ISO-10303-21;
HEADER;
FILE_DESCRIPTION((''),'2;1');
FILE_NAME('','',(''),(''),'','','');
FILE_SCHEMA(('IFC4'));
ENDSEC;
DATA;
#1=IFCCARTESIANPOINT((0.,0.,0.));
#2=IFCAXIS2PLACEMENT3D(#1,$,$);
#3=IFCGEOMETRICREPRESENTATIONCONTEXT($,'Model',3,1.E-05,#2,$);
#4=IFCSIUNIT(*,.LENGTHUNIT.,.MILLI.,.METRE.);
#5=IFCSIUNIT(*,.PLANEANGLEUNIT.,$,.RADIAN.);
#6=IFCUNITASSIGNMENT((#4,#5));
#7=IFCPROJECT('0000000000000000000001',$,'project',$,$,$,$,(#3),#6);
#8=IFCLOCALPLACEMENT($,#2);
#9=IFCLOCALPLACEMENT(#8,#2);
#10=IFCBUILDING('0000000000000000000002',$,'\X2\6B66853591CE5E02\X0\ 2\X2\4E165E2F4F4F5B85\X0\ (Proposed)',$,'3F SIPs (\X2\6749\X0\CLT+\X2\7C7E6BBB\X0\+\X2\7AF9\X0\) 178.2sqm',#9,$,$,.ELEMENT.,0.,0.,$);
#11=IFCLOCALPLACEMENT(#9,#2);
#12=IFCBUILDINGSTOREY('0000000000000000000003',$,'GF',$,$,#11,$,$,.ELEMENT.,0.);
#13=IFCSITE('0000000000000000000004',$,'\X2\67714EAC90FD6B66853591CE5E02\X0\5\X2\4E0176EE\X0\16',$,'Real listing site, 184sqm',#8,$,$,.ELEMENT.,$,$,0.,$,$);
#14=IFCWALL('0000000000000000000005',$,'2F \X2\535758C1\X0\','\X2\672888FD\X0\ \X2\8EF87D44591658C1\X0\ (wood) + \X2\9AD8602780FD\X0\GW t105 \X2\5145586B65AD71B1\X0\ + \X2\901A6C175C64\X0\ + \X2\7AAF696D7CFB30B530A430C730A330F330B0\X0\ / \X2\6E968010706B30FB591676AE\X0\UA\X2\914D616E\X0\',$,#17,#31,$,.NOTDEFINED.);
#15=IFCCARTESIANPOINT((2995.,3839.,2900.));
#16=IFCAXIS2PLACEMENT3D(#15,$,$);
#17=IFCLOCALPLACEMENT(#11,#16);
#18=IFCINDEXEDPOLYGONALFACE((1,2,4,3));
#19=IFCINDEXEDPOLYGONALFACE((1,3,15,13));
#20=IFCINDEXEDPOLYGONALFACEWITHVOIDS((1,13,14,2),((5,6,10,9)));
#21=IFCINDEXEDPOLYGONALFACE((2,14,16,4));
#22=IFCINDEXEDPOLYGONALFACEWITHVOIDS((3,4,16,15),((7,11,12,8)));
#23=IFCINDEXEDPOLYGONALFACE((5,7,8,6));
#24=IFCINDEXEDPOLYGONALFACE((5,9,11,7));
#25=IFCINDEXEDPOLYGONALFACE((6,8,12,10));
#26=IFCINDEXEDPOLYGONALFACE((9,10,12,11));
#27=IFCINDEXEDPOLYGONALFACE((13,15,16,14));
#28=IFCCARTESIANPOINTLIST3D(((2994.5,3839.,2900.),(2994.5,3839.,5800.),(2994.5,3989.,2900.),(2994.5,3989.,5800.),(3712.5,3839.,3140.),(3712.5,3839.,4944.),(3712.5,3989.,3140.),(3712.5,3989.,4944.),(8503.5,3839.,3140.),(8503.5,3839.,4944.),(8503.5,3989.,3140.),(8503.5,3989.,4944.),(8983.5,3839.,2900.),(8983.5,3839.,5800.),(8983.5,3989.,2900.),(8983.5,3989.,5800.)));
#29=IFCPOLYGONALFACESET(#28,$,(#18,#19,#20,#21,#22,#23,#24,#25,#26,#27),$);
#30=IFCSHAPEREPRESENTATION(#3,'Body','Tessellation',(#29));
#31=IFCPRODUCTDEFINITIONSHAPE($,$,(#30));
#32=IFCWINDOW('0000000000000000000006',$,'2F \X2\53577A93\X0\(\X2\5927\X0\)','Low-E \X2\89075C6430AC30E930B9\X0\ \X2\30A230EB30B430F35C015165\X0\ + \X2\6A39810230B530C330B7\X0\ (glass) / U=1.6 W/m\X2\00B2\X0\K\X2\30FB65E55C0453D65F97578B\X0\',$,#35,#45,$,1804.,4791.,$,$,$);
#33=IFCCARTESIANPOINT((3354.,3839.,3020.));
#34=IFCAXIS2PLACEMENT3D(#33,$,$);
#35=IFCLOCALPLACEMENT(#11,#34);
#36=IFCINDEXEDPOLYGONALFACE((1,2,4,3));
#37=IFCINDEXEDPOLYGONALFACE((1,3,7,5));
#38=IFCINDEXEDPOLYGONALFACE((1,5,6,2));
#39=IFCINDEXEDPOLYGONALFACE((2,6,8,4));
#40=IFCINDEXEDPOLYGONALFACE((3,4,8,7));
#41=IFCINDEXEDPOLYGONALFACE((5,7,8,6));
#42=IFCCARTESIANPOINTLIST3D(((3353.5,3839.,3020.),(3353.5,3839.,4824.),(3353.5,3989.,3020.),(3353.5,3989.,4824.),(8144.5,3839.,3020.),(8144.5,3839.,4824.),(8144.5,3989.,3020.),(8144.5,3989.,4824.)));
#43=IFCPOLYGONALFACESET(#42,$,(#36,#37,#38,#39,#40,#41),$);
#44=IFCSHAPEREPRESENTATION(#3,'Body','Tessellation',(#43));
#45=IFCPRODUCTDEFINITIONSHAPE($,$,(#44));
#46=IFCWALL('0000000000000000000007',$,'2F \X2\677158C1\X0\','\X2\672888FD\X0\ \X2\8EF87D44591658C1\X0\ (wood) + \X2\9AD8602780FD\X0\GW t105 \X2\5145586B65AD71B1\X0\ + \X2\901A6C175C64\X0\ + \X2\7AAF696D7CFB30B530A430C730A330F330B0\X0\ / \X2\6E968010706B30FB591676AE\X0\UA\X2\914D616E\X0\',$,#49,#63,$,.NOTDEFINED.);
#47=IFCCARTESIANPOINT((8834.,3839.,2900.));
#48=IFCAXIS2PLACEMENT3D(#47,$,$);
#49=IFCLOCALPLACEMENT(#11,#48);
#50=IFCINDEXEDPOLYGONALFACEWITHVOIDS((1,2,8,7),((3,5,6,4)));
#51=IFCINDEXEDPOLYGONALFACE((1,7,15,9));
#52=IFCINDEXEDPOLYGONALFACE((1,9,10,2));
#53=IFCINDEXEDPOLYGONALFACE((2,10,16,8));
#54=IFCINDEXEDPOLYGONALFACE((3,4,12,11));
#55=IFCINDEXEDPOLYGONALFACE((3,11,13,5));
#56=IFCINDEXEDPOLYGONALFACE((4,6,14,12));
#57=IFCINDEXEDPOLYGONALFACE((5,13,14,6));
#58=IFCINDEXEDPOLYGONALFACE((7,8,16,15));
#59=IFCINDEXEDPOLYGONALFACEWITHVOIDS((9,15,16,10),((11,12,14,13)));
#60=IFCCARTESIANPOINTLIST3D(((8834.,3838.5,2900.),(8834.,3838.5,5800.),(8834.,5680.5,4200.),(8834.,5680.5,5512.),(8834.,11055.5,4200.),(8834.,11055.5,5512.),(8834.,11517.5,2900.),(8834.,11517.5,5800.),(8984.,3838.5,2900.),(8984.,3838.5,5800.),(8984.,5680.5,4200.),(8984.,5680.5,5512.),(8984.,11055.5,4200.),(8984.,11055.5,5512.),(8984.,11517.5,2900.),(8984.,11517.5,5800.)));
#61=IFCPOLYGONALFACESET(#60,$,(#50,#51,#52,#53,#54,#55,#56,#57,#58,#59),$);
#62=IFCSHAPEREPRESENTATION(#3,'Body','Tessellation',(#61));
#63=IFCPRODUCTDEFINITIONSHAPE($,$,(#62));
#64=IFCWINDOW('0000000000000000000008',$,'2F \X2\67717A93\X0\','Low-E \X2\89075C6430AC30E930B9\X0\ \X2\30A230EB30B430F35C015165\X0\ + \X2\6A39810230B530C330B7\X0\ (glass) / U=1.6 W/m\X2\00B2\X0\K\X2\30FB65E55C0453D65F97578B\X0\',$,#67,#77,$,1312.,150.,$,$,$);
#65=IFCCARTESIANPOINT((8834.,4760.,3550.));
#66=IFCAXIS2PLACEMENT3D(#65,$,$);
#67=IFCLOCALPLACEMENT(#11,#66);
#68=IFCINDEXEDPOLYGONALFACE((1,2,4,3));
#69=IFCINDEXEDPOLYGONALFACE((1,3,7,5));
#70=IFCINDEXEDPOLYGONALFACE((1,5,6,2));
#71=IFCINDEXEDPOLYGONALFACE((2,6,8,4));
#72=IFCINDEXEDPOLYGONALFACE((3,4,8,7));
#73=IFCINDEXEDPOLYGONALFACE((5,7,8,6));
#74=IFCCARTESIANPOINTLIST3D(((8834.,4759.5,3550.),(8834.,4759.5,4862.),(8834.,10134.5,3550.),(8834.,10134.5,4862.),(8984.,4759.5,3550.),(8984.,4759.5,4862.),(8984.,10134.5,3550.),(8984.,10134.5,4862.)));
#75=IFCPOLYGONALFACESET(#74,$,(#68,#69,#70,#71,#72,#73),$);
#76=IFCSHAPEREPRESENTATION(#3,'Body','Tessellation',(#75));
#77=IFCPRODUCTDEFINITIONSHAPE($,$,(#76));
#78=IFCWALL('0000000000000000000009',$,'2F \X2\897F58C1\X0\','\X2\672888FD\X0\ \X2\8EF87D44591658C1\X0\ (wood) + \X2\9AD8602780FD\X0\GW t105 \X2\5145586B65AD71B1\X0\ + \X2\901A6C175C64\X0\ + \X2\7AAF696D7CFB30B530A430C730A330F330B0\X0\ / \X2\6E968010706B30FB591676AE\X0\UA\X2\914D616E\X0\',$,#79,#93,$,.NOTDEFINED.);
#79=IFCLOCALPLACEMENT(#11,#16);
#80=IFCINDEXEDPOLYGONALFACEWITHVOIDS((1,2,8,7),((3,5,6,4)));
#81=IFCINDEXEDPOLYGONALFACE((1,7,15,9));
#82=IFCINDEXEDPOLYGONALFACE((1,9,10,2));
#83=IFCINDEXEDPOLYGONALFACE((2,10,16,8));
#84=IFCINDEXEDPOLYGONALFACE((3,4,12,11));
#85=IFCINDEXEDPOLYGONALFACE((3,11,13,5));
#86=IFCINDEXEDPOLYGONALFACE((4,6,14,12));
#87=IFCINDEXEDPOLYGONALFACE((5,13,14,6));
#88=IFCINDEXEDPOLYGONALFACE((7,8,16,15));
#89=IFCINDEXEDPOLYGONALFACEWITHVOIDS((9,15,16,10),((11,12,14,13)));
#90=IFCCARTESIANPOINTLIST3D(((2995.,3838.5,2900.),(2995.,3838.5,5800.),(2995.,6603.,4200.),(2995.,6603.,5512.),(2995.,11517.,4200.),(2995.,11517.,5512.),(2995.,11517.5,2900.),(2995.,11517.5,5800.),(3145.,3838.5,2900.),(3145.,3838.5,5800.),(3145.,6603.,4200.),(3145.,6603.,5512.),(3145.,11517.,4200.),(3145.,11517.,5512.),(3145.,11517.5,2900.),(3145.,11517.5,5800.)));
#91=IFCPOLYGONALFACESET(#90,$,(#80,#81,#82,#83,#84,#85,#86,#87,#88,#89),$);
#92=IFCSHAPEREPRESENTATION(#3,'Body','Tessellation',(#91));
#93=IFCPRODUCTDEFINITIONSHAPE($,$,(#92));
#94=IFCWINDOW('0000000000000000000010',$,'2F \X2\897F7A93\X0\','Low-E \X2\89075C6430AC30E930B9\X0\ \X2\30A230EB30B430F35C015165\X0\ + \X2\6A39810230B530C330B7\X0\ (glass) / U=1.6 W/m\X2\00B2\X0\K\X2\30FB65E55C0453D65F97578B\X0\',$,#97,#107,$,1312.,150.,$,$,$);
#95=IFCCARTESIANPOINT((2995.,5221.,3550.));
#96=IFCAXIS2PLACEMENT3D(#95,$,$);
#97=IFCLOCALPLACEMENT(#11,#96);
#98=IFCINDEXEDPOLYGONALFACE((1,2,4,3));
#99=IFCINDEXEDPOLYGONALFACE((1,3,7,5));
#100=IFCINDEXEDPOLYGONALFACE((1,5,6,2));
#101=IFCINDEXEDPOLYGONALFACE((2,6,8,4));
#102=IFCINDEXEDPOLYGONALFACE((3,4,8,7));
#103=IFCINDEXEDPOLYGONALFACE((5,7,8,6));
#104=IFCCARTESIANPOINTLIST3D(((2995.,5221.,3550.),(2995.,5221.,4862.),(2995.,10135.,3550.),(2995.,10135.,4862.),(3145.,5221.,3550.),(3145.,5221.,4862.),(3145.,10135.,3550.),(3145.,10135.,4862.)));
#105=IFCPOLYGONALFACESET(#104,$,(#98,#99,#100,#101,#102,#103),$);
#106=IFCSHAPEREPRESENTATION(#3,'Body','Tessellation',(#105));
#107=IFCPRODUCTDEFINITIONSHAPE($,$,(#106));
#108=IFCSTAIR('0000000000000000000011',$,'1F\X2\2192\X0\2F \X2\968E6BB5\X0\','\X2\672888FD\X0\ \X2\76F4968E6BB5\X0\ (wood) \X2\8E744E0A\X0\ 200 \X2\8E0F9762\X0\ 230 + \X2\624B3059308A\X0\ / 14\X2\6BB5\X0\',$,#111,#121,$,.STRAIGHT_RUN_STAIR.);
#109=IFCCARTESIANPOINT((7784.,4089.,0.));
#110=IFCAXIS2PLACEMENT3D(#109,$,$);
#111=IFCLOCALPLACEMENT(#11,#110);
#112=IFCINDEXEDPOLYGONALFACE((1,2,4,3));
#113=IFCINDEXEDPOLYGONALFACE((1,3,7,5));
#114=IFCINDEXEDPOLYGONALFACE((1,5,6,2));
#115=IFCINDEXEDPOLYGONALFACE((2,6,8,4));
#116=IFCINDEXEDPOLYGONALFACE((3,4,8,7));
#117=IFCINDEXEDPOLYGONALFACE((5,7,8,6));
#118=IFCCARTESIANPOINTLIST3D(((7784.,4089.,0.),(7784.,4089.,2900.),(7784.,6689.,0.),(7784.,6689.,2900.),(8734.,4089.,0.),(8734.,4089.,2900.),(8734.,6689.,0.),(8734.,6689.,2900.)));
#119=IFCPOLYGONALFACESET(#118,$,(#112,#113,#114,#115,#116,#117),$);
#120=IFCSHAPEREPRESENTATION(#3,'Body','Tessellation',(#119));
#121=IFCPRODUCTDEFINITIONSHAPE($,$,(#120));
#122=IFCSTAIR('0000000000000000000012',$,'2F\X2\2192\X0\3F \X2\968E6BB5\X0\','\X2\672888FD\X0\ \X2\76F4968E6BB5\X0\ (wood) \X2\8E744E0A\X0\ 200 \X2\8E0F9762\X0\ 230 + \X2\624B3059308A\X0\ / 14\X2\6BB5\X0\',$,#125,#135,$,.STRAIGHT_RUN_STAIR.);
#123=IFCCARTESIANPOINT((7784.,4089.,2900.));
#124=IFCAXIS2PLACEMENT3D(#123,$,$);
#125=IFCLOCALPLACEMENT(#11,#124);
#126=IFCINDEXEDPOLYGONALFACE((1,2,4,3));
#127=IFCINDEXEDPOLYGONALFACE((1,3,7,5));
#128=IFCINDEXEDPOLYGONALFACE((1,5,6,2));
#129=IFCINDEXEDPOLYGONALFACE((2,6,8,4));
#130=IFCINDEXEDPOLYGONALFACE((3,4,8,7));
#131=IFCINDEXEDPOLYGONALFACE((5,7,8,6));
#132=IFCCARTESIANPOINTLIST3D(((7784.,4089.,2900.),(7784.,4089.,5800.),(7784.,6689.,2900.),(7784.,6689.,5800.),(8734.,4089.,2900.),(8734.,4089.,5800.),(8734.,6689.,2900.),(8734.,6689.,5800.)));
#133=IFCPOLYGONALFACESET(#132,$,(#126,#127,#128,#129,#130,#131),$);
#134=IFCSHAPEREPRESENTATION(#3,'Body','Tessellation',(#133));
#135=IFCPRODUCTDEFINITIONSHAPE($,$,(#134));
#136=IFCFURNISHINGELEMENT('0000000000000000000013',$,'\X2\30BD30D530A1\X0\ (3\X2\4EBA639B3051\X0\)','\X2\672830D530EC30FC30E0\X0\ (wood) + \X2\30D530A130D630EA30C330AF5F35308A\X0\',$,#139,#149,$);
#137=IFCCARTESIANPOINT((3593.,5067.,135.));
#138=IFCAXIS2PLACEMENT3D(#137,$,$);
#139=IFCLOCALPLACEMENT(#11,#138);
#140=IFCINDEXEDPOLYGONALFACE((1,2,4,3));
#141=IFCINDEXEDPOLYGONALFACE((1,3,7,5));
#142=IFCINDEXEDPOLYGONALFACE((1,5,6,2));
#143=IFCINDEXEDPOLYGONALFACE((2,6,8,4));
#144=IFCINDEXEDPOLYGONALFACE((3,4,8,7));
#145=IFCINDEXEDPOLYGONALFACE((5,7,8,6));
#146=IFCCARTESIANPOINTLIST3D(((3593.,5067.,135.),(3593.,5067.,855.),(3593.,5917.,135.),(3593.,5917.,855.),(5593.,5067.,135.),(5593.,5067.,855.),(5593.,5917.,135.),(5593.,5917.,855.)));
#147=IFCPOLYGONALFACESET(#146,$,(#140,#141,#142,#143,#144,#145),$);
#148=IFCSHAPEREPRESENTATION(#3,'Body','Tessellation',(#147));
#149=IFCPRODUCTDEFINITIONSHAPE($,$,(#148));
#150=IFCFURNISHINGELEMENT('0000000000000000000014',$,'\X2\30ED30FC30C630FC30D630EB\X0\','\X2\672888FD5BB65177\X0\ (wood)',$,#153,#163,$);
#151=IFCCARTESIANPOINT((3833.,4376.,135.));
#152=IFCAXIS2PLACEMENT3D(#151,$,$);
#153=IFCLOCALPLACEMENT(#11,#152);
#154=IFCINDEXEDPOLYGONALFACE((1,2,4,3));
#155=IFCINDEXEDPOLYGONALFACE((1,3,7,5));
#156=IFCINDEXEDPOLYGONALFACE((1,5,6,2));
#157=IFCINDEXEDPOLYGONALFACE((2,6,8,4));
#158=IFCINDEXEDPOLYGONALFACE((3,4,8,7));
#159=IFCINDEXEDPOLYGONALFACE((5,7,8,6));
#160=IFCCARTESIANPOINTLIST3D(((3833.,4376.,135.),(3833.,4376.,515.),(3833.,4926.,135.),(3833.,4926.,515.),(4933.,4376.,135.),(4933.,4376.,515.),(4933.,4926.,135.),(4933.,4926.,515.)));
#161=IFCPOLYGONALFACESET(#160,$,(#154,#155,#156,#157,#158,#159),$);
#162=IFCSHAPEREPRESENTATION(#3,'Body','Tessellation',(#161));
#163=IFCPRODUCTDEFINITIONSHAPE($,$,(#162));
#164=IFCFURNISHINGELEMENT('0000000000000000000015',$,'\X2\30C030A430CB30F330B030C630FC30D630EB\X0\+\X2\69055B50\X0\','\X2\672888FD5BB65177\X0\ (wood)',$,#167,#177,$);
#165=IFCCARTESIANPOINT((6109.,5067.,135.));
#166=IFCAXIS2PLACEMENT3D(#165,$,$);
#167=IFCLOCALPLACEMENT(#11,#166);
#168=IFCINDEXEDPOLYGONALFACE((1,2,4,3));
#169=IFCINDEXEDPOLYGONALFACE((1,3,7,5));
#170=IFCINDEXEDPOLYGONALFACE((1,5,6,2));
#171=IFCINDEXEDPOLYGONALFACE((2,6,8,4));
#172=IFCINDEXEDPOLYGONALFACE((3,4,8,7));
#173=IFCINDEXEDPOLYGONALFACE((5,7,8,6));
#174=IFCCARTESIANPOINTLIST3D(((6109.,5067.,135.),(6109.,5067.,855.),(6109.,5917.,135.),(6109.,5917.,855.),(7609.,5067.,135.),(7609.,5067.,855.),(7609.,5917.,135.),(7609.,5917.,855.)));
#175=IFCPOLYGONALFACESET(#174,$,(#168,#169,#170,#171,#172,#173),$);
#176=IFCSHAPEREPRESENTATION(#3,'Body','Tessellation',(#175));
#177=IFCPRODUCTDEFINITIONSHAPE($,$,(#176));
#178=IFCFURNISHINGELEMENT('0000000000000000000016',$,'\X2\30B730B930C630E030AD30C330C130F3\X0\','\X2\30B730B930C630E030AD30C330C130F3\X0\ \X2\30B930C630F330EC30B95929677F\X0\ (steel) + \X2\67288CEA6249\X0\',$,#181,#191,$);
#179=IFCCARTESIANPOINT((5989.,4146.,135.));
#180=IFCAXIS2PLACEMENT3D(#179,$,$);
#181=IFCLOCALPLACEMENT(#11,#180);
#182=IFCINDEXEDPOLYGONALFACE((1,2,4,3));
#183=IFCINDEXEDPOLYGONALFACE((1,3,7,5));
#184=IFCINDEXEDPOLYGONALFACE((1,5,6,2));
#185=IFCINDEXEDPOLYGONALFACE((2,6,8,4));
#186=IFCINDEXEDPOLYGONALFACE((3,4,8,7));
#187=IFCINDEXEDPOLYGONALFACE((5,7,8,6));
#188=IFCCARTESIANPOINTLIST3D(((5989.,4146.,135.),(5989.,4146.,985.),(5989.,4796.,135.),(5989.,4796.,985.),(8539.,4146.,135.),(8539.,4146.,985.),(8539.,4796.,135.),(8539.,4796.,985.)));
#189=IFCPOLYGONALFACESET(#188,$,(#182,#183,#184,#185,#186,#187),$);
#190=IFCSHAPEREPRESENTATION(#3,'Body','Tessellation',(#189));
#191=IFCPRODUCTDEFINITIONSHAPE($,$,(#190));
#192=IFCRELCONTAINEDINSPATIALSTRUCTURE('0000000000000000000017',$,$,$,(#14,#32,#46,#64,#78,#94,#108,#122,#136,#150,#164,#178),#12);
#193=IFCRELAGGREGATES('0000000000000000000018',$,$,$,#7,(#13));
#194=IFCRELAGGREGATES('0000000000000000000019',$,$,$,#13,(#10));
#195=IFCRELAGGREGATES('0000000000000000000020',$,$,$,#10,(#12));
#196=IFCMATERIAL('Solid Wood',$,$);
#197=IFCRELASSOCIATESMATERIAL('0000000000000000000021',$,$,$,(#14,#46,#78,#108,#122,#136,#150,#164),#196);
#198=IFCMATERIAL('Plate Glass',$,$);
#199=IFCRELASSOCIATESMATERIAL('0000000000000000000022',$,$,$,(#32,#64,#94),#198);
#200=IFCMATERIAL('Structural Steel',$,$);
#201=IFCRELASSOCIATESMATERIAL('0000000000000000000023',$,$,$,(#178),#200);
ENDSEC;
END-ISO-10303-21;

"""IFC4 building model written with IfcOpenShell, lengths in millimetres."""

from ifc_helpers import new_model, si_unit, frame, frame_2d, origin, place, context, project, spatial, rectangle, extrude, material, element, fill, save


model = new_model("IFC4")

# Units and contexts
model_context = context("Model", 3, precision=1e-05, world=origin())
ifc_project = project(units=[si_unit("LENGTHUNIT", "METRE", prefix="MILLI"), si_unit("PLANEANGLEUNIT", "RADIAN")], contexts=[model_context])

# Site, building, storey
site_placement = place(None, origin())
site = spatial("IfcSite", under=ifc_project, at=site_placement, Name="東京都武蔵野市5丁目16", ObjectType="Real listing site, 184sqm", CompositionType="ELEMENT", RefElevation=0.0)
building_placement = place(site_placement, origin())
building = spatial("IfcBuilding", under=site, at=building_placement, Name="武蔵野市 2世帯住宅 (Proposed)", ObjectType="3F SIPs (杉CLT+籾殻+竹) 178.2sqm", CompositionType="ELEMENT", ElevationOfRefHeight=0.0, ElevationOfTerrain=0.0)
storey_placement = place(building_placement, origin())
storey = spatial("IfcBuildingStorey", under=building, at=storey_placement, Name="GF", CompositionType="ELEMENT", Elevation=0.0)

# Shared definitions
ifc_material_1 = material(Name="Solid Wood")

# Shared definitions
ifc_material_2 = material(Name="Plate Glass")

# Walls, openings, windows
wall_1_placement = place(storey_placement, frame((2995.0, 3839.0, 2900.0)))
wall_1 = element("IfcWall", 1, at=wall_1_placement, inside=storey, material=ifc_material_1, Name="2F 南壁", Description="木製 軸組外壁 (wood) + 高性能GW t105 充填断熱 + 通気層 + 窯業系サイディング / 準耐火・外皮UA配慮", PredefinedType="NOTDEFINED", context=model_context, shape_type="SweptSolid", body=[
    extrude(rectangle(XDim=5989.0, YDim=150.0, at=frame_2d((2994.0, 75.0))), frame((2995.0, 3839.0, 2900.0)), (0.0, 0.0, 1.0), 2900.0),
])
opening_1_placement = place(storey_placement, frame((3354.0, 3839.0, 3020.0)))
opening_1 = element("IfcOpeningElement", 2, at=opening_1_placement, cuts=wall_1, PredefinedType="NOTDEFINED", context=model_context, shape_type="SweptSolid", body=[
    extrude(rectangle(XDim=4791.0, YDim=150.0, at=frame_2d((2395.0, 75.0))), frame((3354.0, 3839.0, 3020.0)), (0.0, 0.0, 1.0), 1804.0),
])
window_1_placement = place(storey_placement, frame((3354.0, 3839.0, 3020.0)))
window_1 = element("IfcWindow", 3, at=window_1_placement, inside=storey, material=ifc_material_2, Name="2F 南窓(大)", Description="Low-E 複層ガラス アルゴン封入 + 樹脂サッシ (glass) / U=1.6 W/m²K・日射取得型", OverallHeight=1804.0, OverallWidth=4791.0, context=model_context, shape_type="SweptSolid", body=[
    extrude(rectangle(XDim=4791.0, YDim=150.0, at=frame_2d((2395.0, 75.0))), frame((3354.0, 3839.0, 3020.0)), (0.0, 0.0, 1.0), 1804.0),
])
fill(opening_1, window_1)
wall_2_placement = place(storey_placement, frame((8834.0, 3839.0, 2900.0)))
wall_2 = element("IfcWall", 4, at=wall_2_placement, inside=storey, material=ifc_material_1, Name="2F 東壁", Description="木製 軸組外壁 (wood) + 高性能GW t105 充填断熱 + 通気層 + 窯業系サイディング / 準耐火・外皮UA配慮", PredefinedType="NOTDEFINED", context=model_context, shape_type="SweptSolid", body=[
    extrude(rectangle(XDim=150.0, YDim=7679.0, at=frame_2d((75.0, 3839.0))), frame((8834.0, 3839.0, 2900.0)), (0.0, 0.0, 1.0), 2900.0),
])
opening_2_placement = place(storey_placement, frame((8834.0, 4760.0, 3550.0)))
opening_2 = element("IfcOpeningElement", 5, at=opening_2_placement, cuts=wall_2, PredefinedType="NOTDEFINED", context=model_context, shape_type="SweptSolid", body=[
    extrude(rectangle(XDim=150.0, YDim=5375.0, at=frame_2d((75.0, 2687.0))), frame((8834.0, 4760.0, 3550.0)), (0.0, 0.0, 1.0), 1312.0),
])
window_2_placement = place(storey_placement, frame((8834.0, 4760.0, 3550.0)))
window_2 = element("IfcWindow", 6, at=window_2_placement, inside=storey, material=ifc_material_2, Name="2F 東窓", Description="Low-E 複層ガラス アルゴン封入 + 樹脂サッシ (glass) / U=1.6 W/m²K・日射取得型", OverallHeight=1312.0, OverallWidth=150.0, context=model_context, shape_type="SweptSolid", body=[
    extrude(rectangle(XDim=150.0, YDim=5375.0, at=frame_2d((75.0, 2687.0))), frame((8834.0, 4760.0, 3550.0)), (0.0, 0.0, 1.0), 1312.0),
])
fill(opening_2, window_2)
wall_3_placement = place(storey_placement, frame((2995.0, 3839.0, 2900.0)))
wall_3 = element("IfcWall", 7, at=wall_3_placement, inside=storey, material=ifc_material_1, Name="2F 西壁", Description="木製 軸組外壁 (wood) + 高性能GW t105 充填断熱 + 通気層 + 窯業系サイディング / 準耐火・外皮UA配慮", PredefinedType="NOTDEFINED", context=model_context, shape_type="SweptSolid", body=[
    extrude(rectangle(XDim=150.0, YDim=7679.0, at=frame_2d((75.0, 3839.0))), frame((2995.0, 3839.0, 2900.0)), (0.0, 0.0, 1.0), 2900.0),
])
opening_3_placement = place(storey_placement, frame((2995.0, 5221.0, 3550.0)))
opening_3 = element("IfcOpeningElement", 8, at=opening_3_placement, cuts=wall_3, PredefinedType="NOTDEFINED", context=model_context, shape_type="SweptSolid", body=[
    extrude(rectangle(XDim=150.0, YDim=4914.0, at=frame_2d((75.0, 2457.0))), frame((2995.0, 5221.0, 3550.0)), (0.0, 0.0, 1.0), 1312.0),
])
window_3_placement = place(storey_placement, frame((2995.0, 5221.0, 3550.0)))
window_3 = element("IfcWindow", 9, at=window_3_placement, inside=storey, material=ifc_material_2, Name="2F 西窓", Description="Low-E 複層ガラス アルゴン封入 + 樹脂サッシ (glass) / U=1.6 W/m²K・日射取得型", OverallHeight=1312.0, OverallWidth=150.0, context=model_context, shape_type="SweptSolid", body=[
    extrude(rectangle(XDim=150.0, YDim=4914.0, at=frame_2d((75.0, 2457.0))), frame((2995.0, 5221.0, 3550.0)), (0.0, 0.0, 1.0), 1312.0),
])
fill(opening_3, window_3)

# Stairs
stair_1_placement = place(storey_placement, frame((7784.0, 4089.0, 0.0)))
element("IfcStair", 10, at=stair_1_placement, inside=storey, material=ifc_material_1, Name="1F→2F 階段", Description="木製 直階段 (wood) 蹴上 200 踏面 230 + 手すり / 14段", PredefinedType="STRAIGHT_RUN_STAIR", context=model_context, shape_type="SweptSolid", body=[
    extrude(rectangle(XDim=950.0, YDim=2600.0, at=frame_2d((475.0, 1300.0))), frame((7784.0, 4089.0, 0.0)), (0.0, 0.0, 1.0), 2900.0),
])
stair_2_placement = place(storey_placement, frame((7784.0, 4089.0, 2900.0)))
element("IfcStair", 11, at=stair_2_placement, inside=storey, material=ifc_material_1, Name="2F→3F 階段", Description="木製 直階段 (wood) 蹴上 200 踏面 230 + 手すり / 14段", PredefinedType="STRAIGHT_RUN_STAIR", context=model_context, shape_type="SweptSolid", body=[
    extrude(rectangle(XDim=950.0, YDim=2600.0, at=frame_2d((475.0, 1300.0))), frame((7784.0, 4089.0, 2900.0)), (0.0, 0.0, 1.0), 2900.0),
])

# Furnishing elements
furnishing_1_placement = place(storey_placement, frame((3593.0, 5067.0, 135.0)))
element("IfcFurnishingElement", 12, at=furnishing_1_placement, inside=storey, material=ifc_material_1, Name="ソファ (3人掛け)", Description="木フレーム (wood) + ファブリック張り", context=model_context, shape_type="SweptSolid", body=[
    extrude(rectangle(XDim=2000.0, YDim=850.0, at=frame_2d((1000.0, 425.0))), frame((3593.0, 5067.0, 135.0)), (0.0, 0.0, 1.0), 720.0),
])
furnishing_2_placement = place(storey_placement, frame((3833.0, 4376.0, 135.0)))
element("IfcFurnishingElement", 13, at=furnishing_2_placement, inside=storey, material=ifc_material_1, Name="ローテーブル", Description="木製家具 (wood)", context=model_context, shape_type="SweptSolid", body=[
    extrude(rectangle(XDim=1100.0, YDim=550.0, at=frame_2d((550.0, 275.0))), frame((3833.0, 4376.0, 135.0)), (0.0, 0.0, 1.0), 380.0),
])
furnishing_3_placement = place(storey_placement, frame((6109.0, 5067.0, 135.0)))
element("IfcFurnishingElement", 14, at=furnishing_3_placement, inside=storey, material=ifc_material_1, Name="ダイニングテーブル+椅子", Description="木製家具 (wood)", context=model_context, shape_type="SweptSolid", body=[
    extrude(rectangle(XDim=1500.0, YDim=850.0, at=frame_2d((750.0, 425.0))), frame((6109.0, 5067.0, 135.0)), (0.0, 0.0, 1.0), 720.0),
])
ifc_material_3 = material(Name="Structural Steel")
furnishing_4_placement = place(storey_placement, frame((5989.0, 4146.0, 135.0)))
element("IfcFurnishingElement", 15, at=furnishing_4_placement, inside=storey, material=ifc_material_3, Name="システムキッチン", Description="システムキッチン ステンレス天板 (steel) + 木質扉", context=model_context, shape_type="SweptSolid", body=[
    extrude(rectangle(XDim=2550.0, YDim=650.0, at=frame_2d((1275.0, 325.0))), frame((5989.0, 4146.0, 135.0)), (0.0, 0.0, 1.0), 850.0),
])

save(model, "model.ifc")
